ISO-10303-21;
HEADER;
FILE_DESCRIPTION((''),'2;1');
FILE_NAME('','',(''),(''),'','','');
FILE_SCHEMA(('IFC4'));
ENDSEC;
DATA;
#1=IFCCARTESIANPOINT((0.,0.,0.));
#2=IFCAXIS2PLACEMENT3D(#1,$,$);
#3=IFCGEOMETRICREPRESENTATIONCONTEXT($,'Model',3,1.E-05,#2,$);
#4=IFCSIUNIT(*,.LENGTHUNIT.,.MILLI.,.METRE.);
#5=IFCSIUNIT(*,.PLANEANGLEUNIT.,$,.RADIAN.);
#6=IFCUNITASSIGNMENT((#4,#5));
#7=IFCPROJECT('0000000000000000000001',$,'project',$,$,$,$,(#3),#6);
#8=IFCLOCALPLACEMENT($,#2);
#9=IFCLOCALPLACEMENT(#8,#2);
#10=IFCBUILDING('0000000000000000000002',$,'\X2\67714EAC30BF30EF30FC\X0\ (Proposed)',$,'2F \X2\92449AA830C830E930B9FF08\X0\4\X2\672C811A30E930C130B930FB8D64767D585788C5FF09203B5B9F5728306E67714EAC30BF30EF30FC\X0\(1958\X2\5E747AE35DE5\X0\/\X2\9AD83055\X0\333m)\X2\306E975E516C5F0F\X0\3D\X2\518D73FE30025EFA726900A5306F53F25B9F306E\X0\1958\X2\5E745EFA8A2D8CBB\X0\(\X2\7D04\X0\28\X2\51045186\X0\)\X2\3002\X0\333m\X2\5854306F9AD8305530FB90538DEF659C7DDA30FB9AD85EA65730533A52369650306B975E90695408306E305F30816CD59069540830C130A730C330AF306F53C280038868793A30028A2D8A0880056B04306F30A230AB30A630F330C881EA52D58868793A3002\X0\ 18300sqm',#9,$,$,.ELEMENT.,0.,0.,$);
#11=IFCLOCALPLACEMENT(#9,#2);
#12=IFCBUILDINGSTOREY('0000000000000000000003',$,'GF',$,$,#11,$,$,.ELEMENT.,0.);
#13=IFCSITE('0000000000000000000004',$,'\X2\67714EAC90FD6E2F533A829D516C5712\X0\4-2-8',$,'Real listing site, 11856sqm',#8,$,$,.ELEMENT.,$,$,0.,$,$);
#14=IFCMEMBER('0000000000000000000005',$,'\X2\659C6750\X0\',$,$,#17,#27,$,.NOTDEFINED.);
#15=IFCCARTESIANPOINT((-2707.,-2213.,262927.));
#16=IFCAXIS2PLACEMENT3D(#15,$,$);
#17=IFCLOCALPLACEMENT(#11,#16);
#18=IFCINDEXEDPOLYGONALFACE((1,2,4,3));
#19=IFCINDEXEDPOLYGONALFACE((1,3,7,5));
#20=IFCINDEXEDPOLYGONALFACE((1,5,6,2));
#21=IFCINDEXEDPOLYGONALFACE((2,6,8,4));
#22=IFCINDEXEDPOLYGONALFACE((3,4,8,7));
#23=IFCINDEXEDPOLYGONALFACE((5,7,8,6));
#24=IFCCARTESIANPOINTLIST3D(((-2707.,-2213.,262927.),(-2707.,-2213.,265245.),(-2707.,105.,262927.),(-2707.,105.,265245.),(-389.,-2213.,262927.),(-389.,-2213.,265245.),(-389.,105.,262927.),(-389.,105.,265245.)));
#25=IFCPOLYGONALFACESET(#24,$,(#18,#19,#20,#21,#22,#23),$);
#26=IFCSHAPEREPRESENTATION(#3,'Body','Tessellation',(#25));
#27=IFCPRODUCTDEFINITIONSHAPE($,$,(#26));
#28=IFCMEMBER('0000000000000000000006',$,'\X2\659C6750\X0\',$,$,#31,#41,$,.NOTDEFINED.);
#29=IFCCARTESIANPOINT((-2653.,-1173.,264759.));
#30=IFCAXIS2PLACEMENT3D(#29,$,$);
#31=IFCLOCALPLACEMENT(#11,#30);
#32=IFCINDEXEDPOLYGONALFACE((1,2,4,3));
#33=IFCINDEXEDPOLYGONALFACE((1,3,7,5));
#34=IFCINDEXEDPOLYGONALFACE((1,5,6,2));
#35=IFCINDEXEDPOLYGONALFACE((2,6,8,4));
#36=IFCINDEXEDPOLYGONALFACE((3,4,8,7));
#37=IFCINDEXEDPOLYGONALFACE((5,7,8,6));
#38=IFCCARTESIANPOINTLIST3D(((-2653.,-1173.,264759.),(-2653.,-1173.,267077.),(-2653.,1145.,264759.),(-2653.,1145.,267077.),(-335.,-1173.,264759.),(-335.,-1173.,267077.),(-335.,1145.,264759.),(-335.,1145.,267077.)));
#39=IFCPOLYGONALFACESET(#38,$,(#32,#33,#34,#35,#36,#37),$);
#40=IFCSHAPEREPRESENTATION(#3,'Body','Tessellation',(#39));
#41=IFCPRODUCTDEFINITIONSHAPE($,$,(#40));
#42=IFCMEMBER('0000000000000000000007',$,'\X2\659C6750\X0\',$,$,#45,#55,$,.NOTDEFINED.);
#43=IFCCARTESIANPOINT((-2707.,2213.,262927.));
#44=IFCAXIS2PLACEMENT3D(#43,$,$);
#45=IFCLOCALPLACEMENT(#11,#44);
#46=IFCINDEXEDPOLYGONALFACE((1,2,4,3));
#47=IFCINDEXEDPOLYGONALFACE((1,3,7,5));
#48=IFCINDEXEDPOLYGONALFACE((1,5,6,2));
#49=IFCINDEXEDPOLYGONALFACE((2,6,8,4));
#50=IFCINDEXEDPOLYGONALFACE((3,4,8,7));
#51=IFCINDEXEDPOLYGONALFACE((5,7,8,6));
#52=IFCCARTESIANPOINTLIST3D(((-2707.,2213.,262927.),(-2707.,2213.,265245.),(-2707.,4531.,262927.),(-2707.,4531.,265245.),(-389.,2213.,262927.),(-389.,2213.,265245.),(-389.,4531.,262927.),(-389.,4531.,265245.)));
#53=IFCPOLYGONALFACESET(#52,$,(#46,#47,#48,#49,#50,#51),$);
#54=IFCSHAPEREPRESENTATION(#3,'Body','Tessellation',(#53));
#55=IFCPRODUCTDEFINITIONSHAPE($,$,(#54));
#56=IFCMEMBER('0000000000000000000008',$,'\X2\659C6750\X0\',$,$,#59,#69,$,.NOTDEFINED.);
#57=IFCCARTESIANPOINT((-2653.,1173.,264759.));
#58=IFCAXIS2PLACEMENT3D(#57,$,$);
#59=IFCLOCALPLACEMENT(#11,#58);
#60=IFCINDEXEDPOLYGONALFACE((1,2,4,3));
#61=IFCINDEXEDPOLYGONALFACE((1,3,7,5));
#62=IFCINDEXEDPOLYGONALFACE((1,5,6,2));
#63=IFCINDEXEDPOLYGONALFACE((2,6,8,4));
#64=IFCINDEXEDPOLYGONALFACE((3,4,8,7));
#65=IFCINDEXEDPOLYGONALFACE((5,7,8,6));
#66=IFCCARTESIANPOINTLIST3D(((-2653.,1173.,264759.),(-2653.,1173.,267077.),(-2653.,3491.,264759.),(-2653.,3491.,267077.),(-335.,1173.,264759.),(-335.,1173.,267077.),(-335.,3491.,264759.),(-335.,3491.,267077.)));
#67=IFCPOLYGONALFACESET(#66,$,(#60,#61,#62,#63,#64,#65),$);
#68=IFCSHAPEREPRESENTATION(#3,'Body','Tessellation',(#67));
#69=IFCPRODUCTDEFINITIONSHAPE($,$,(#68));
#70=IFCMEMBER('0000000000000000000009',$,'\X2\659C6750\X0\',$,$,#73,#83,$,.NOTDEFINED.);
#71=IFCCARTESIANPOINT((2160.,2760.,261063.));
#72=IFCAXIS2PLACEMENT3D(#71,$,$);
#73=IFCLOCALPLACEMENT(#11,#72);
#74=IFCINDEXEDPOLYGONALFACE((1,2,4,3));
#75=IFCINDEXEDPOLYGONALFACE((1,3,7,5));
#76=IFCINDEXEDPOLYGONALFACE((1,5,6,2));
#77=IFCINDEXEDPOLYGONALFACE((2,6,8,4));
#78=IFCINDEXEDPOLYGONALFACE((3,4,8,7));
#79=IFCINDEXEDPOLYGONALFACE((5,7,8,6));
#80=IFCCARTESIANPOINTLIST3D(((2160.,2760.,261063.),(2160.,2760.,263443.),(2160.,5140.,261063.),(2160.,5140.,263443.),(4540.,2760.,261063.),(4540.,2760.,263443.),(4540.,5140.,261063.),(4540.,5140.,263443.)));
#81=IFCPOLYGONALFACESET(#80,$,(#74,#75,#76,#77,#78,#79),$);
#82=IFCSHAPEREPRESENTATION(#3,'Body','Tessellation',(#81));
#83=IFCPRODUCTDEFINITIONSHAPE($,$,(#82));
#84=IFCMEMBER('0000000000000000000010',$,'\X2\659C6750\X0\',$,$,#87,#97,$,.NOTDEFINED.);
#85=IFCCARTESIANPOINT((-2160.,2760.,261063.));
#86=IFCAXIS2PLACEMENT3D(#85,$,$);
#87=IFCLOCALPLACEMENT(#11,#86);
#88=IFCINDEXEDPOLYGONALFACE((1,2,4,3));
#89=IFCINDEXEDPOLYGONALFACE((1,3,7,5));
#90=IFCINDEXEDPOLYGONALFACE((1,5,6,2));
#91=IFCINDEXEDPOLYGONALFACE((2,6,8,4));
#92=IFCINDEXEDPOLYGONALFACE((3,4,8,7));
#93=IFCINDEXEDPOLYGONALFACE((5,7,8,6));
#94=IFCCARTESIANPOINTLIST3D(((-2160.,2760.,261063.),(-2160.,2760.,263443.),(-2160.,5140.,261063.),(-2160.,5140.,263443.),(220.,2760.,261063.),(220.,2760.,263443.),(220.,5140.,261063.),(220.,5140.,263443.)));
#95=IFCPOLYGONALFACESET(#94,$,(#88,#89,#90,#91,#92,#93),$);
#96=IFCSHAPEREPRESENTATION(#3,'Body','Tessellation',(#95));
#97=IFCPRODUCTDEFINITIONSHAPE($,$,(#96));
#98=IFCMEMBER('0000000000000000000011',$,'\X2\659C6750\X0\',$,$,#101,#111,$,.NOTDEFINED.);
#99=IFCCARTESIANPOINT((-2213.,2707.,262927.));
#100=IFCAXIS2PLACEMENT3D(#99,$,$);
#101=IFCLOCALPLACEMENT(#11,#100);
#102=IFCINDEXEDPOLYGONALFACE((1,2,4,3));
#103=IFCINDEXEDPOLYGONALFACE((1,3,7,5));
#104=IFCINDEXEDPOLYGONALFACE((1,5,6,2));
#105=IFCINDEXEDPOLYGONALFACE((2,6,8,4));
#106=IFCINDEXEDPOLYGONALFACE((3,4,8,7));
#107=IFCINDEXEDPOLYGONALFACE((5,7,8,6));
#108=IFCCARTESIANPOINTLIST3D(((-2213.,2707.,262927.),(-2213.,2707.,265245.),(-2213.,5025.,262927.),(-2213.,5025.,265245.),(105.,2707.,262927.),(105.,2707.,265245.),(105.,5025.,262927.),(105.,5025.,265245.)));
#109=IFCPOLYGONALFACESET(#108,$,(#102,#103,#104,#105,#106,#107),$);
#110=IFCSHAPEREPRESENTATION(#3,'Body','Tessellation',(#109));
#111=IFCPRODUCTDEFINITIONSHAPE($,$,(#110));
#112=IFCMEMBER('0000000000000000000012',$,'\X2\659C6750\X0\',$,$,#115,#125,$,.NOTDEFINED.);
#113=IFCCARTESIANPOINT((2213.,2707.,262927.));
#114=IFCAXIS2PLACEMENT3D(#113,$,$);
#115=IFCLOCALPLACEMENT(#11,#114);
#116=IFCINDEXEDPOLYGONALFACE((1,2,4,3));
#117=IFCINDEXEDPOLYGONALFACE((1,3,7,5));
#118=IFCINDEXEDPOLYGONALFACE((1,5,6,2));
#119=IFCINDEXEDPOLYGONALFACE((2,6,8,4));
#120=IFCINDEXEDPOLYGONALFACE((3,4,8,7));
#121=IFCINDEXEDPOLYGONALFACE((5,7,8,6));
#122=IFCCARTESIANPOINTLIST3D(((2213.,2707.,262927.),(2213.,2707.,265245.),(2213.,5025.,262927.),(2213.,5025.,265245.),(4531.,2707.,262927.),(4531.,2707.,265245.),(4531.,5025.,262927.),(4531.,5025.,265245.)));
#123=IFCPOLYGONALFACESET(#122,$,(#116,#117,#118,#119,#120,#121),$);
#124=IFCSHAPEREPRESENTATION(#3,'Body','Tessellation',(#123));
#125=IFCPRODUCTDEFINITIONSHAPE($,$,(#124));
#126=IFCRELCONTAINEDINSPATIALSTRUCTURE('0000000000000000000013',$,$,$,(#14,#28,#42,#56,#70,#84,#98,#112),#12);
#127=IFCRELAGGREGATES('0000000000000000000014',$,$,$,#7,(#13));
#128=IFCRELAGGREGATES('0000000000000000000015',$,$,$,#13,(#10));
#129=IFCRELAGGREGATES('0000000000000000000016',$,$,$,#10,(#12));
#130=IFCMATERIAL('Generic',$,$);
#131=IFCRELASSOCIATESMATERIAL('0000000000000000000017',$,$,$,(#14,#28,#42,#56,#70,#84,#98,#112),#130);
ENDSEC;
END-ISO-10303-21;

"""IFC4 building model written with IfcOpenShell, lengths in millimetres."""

from ifc_helpers import new_model, si_unit, frame, frame_2d, origin, place, context, project, spatial, rectangle, extrude, material, element, save


model = new_model("IFC4")

# Units and contexts
model_context = context("Model", 3, precision=1e-05, world=origin())
ifc_project = project(units=[si_unit("LENGTHUNIT", "METRE", prefix="MILLI"), si_unit("PLANEANGLEUNIT", "RADIAN")], contexts=[model_context])

# Site, building, storey
site_placement = place(None, origin())
site = spatial("IfcSite", under=ifc_project, at=site_placement, Name="東京都港区芝公園4-2-8", ObjectType="Real listing site, 11856sqm", CompositionType="ELEMENT", RefElevation=0.0)
building_placement = place(site_placement, origin())
building = spatial("IfcBuilding", under=site, at=building_placement, Name="東京タワー (Proposed)", ObjectType="2F 鉄骨トラス（4本脚ラチス・赤白塗装）※実在の東京タワー(1958年竣工/高さ333m)の非公式3D再現。建物¥は史実の1958年建設費(約28億円)。333m塔は高さ・道路斜線・高度地区制限に非適合のため法適合チェックは参考表示。設計者欄はアカウント自動表示。 18300sqm", CompositionType="ELEMENT", ElevationOfRefHeight=0.0, ElevationOfTerrain=0.0)
storey_placement = place(building_placement, origin())
storey = spatial("IfcBuildingStorey", under=building, at=storey_placement, Name="GF", CompositionType="ELEMENT", Elevation=0.0)

# Shared definitions
ifc_material = material(Name="Generic")

# Members
member_1_placement = place(storey_placement, frame((-2707.0, -2213.0, 262927.0)))
element("IfcMember", 1, at=member_1_placement, inside=storey, material=ifc_material, Name="斜材", PredefinedType="NOTDEFINED", context=model_context, shape_type="SweptSolid", body=[
    extrude(rectangle(XDim=2318.0, YDim=2318.0, at=frame_2d((1159.0, 1159.0))), frame((-2707.0, -2213.0, 262927.0)), (0.0, 0.0, 1.0), 2318.0),
])
member_2_placement = place(storey_placement, frame((-2653.0, -1173.0, 264759.0)))
element("IfcMember", 2, at=member_2_placement, inside=storey, material=ifc_material, Name="斜材", PredefinedType="NOTDEFINED", context=model_context, shape_type="SweptSolid", body=[
    extrude(rectangle(XDim=2318.0, YDim=2318.0, at=frame_2d((1159.0, 1159.0))), frame((-2653.0, -1173.0, 264759.0)), (0.0, 0.0, 1.0), 2318.0),
])
member_3_placement = place(storey_placement, frame((-2707.0, 2213.0, 262927.0)))
element("IfcMember", 3, at=member_3_placement, inside=storey, material=ifc_material, Name="斜材", PredefinedType="NOTDEFINED", context=model_context, shape_type="SweptSolid", body=[
    extrude(rectangle(XDim=2318.0, YDim=2318.0, at=frame_2d((1159.0, 1159.0))), frame((-2707.0, 2213.0, 262927.0)), (0.0, 0.0, 1.0), 2318.0),
])
member_4_placement = place(storey_placement, frame((-2653.0, 1173.0, 264759.0)))
element("IfcMember", 4, at=member_4_placement, inside=storey, material=ifc_material, Name="斜材", PredefinedType="NOTDEFINED", context=model_context, shape_type="SweptSolid", body=[
    extrude(rectangle(XDim=2318.0, YDim=2318.0, at=frame_2d((1159.0, 1159.0))), frame((-2653.0, 1173.0, 264759.0)), (0.0, 0.0, 1.0), 2318.0),
])
member_5_placement = place(storey_placement, frame((2160.0, 2760.0, 261063.0)))
element("IfcMember", 5, at=member_5_placement, inside=storey, material=ifc_material, Name="斜材", PredefinedType="NOTDEFINED", context=model_context, shape_type="SweptSolid", body=[
    extrude(rectangle(XDim=2380.0, YDim=2380.0, at=frame_2d((1190.0, 1190.0))), frame((2160.0, 2760.0, 261063.0)), (0.0, 0.0, 1.0), 2380.0),
])
member_6_placement = place(storey_placement, frame((-2160.0, 2760.0, 261063.0)))
element("IfcMember", 6, at=member_6_placement, inside=storey, material=ifc_material, Name="斜材", PredefinedType="NOTDEFINED", context=model_context, shape_type="SweptSolid", body=[
    extrude(rectangle(XDim=2380.0, YDim=2380.0, at=frame_2d((1190.0, 1190.0))), frame((-2160.0, 2760.0, 261063.0)), (0.0, 0.0, 1.0), 2380.0),
])
member_7_placement = place(storey_placement, frame((-2213.0, 2707.0, 262927.0)))
element("IfcMember", 7, at=member_7_placement, inside=storey, material=ifc_material, Name="斜材", PredefinedType="NOTDEFINED", context=model_context, shape_type="SweptSolid", body=[
    extrude(rectangle(XDim=2318.0, YDim=2318.0, at=frame_2d((1159.0, 1159.0))), frame((-2213.0, 2707.0, 262927.0)), (0.0, 0.0, 1.0), 2318.0),
])
member_8_placement = place(storey_placement, frame((2213.0, 2707.0, 262927.0)))
element("IfcMember", 8, at=member_8_placement, inside=storey, material=ifc_material, Name="斜材", PredefinedType="NOTDEFINED", context=model_context, shape_type="SweptSolid", body=[
    extrude(rectangle(XDim=2318.0, YDim=2318.0, at=frame_2d((1159.0, 1159.0))), frame((2213.0, 2707.0, 262927.0)), (0.0, 0.0, 1.0), 2318.0),
])

save(model, "model.ifc")
